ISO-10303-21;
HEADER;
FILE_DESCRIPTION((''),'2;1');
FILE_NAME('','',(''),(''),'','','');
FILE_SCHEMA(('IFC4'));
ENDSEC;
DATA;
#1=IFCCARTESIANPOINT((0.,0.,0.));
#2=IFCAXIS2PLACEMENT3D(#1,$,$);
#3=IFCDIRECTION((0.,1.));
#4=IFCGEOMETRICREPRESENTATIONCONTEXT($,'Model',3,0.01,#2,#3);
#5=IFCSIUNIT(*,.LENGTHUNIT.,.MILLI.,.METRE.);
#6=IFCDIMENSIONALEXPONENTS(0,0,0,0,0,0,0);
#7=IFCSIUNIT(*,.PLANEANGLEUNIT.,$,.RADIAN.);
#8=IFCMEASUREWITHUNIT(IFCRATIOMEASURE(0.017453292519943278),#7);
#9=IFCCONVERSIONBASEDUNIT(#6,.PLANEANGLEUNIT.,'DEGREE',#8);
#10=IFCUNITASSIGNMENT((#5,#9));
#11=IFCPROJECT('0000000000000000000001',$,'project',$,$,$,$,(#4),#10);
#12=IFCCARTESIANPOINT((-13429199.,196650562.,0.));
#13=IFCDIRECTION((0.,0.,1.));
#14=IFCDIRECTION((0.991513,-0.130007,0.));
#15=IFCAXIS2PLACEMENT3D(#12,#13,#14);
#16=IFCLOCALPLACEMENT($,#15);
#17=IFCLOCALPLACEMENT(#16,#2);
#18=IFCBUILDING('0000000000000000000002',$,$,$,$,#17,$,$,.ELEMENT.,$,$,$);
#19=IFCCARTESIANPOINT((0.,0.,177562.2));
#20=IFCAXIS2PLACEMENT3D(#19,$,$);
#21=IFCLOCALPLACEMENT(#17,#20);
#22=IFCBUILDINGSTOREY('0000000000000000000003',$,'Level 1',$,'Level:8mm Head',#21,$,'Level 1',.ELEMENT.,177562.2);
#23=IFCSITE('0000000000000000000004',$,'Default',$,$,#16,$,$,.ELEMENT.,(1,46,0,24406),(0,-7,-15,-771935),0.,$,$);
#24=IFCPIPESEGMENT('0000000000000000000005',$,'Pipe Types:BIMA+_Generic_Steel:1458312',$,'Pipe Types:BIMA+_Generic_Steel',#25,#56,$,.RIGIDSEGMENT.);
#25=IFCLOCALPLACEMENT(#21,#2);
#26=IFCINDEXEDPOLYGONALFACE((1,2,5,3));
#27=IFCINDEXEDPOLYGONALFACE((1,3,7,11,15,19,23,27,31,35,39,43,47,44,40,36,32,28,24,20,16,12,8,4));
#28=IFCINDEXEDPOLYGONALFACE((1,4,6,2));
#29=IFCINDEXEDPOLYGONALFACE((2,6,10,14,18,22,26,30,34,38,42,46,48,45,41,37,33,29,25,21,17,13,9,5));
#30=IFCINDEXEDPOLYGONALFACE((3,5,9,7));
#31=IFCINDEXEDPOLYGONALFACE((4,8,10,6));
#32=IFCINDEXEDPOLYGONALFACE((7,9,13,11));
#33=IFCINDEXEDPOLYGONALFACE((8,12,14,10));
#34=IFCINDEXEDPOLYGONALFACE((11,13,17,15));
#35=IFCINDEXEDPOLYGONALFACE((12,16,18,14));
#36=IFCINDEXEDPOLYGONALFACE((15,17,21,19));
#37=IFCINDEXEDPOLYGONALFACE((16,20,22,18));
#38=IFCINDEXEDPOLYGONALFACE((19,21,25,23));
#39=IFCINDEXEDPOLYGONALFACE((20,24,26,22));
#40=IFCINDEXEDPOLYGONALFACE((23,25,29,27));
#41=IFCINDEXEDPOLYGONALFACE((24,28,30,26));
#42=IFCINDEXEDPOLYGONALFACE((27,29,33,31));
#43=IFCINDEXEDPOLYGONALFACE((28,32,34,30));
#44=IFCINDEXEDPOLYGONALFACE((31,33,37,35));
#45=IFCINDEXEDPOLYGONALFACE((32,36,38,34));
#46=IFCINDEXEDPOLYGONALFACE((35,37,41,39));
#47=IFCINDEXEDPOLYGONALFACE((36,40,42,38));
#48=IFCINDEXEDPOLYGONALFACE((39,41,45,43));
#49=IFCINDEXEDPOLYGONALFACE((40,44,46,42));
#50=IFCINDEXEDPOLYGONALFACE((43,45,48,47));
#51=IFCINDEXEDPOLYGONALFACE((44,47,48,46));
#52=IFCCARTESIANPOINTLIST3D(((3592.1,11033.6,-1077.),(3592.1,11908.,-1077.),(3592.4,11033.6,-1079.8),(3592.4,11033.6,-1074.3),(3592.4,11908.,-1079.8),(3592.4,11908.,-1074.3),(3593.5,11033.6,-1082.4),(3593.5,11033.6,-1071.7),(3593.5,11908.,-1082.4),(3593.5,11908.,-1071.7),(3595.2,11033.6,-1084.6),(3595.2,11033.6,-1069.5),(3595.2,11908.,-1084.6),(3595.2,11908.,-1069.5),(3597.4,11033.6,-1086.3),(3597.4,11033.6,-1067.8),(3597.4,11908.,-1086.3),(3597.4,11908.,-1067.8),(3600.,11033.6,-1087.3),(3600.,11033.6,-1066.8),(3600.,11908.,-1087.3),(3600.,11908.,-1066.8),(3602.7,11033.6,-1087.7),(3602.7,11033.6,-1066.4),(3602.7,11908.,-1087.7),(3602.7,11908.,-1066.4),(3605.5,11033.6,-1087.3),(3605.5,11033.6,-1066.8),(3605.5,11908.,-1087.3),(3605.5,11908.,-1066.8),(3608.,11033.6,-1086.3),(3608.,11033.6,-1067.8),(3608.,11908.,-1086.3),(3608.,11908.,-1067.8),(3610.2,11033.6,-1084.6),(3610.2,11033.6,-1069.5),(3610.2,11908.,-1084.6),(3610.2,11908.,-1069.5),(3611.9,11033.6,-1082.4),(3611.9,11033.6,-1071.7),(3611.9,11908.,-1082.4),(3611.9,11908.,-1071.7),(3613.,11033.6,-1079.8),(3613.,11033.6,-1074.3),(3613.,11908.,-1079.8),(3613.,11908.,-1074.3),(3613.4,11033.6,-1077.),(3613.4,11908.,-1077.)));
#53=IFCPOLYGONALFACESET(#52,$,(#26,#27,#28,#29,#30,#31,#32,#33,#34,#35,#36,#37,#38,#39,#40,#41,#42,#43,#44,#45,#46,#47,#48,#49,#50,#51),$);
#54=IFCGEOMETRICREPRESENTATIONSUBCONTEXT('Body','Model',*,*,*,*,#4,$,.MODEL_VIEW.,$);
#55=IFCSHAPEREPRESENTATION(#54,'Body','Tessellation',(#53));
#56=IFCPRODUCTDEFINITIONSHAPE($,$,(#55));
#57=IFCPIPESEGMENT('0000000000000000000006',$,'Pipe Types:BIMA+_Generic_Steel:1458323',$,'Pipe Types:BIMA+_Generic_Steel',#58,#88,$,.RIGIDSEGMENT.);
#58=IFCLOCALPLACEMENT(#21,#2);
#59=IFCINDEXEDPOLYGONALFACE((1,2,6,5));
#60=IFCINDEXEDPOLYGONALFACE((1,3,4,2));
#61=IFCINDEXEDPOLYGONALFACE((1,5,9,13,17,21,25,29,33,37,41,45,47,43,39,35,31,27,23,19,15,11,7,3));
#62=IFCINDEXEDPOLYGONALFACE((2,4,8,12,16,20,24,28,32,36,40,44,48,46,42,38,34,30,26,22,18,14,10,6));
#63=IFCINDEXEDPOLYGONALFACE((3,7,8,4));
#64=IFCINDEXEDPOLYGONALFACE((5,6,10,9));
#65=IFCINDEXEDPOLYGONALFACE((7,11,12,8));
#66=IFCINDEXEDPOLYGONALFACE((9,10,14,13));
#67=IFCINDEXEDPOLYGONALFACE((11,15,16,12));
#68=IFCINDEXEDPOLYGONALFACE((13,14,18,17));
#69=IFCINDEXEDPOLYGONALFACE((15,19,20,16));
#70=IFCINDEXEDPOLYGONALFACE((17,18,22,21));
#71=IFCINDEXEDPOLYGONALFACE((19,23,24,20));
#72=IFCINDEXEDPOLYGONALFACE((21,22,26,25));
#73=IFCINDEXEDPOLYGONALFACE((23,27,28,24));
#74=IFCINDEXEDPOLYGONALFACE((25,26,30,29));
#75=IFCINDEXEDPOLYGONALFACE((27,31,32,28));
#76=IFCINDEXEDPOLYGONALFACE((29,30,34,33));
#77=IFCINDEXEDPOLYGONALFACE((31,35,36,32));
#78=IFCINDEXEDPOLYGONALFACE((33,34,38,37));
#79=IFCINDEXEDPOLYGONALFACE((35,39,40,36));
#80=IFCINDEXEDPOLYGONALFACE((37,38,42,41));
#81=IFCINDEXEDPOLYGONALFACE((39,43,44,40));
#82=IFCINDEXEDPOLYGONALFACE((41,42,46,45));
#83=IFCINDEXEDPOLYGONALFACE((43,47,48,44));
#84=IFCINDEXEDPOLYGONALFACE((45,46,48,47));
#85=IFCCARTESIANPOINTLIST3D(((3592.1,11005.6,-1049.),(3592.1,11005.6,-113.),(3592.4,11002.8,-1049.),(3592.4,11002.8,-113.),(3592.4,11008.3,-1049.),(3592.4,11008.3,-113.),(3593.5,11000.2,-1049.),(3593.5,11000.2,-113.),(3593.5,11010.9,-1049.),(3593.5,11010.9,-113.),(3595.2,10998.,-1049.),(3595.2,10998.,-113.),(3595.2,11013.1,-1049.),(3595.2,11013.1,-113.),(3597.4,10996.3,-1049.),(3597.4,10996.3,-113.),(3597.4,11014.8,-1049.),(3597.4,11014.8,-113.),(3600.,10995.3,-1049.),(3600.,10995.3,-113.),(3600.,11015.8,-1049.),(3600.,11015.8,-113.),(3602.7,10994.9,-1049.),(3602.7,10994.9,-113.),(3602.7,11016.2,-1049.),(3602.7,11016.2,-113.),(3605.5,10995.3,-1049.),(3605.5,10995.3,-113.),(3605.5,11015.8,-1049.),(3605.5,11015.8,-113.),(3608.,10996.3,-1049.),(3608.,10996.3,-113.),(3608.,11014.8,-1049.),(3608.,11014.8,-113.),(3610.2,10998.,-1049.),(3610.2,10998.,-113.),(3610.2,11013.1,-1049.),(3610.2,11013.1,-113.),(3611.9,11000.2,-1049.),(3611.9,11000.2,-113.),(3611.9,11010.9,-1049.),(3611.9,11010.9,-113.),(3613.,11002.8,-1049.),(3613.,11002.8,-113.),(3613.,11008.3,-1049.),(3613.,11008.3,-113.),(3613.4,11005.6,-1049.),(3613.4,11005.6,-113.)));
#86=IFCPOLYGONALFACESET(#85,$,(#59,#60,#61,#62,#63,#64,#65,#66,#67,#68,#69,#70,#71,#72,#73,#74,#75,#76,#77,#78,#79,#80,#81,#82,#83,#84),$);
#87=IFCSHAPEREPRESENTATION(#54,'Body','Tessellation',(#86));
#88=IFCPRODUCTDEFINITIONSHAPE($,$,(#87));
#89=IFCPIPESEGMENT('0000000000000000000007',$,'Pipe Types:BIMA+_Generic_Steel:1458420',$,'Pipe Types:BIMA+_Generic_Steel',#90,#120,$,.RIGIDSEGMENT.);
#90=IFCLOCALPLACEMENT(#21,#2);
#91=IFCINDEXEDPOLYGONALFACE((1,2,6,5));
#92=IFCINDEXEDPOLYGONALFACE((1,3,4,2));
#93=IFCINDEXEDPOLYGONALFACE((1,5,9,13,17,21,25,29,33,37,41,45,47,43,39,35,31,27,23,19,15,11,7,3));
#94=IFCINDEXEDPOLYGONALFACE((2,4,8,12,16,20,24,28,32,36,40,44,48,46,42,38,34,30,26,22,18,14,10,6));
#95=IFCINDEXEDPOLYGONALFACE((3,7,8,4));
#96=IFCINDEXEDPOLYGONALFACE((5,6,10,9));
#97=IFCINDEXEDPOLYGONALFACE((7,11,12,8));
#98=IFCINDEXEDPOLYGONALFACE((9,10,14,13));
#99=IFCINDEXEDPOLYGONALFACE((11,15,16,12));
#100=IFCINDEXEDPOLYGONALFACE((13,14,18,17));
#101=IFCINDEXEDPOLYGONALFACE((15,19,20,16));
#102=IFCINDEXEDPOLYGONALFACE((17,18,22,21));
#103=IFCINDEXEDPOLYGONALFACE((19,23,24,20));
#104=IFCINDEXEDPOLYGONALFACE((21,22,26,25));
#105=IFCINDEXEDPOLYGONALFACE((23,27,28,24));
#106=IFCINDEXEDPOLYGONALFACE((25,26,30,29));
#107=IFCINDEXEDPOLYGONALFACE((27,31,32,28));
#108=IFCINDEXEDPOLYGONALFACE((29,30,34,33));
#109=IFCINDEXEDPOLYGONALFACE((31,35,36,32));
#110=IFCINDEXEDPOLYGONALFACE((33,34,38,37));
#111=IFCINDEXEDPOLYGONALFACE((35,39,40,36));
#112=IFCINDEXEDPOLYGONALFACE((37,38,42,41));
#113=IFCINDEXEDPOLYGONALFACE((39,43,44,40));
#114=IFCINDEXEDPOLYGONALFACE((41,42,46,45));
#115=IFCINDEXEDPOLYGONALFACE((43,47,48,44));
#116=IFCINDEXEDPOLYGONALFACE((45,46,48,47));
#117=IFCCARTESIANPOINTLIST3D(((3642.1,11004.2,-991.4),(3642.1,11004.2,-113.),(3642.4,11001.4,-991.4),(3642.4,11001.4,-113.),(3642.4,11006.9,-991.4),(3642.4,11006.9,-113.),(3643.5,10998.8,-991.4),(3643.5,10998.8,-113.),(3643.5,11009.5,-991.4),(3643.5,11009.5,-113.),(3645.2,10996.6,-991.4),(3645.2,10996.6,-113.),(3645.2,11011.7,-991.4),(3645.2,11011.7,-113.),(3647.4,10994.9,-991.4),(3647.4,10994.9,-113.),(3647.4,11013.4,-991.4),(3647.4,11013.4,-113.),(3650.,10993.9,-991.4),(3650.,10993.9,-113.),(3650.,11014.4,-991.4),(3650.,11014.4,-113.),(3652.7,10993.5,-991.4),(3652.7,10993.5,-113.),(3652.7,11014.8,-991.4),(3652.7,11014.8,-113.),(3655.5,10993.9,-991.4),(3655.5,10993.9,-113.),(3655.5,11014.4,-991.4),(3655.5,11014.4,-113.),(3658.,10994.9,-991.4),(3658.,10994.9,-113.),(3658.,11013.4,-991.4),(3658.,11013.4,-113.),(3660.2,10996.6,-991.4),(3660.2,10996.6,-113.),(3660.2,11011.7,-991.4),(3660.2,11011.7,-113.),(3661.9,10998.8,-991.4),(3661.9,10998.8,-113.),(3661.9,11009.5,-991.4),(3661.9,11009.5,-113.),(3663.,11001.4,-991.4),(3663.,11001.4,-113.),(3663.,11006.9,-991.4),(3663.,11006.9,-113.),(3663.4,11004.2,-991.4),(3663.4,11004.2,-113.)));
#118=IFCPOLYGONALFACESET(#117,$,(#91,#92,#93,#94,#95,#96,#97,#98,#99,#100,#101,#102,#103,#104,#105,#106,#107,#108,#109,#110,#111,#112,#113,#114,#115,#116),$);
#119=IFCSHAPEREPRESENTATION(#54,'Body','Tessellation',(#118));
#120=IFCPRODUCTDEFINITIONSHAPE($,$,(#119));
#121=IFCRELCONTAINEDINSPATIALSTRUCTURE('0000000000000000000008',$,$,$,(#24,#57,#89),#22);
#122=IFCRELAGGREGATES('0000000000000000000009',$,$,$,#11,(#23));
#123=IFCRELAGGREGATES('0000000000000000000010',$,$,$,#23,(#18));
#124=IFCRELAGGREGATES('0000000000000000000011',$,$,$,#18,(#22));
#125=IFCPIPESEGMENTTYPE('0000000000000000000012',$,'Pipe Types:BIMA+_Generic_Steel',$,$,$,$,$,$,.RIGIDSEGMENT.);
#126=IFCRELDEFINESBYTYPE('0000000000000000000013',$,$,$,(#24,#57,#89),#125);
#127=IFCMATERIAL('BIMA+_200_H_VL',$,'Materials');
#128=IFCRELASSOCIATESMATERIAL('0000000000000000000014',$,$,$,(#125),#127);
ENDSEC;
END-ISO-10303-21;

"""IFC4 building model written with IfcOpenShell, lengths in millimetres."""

from ifc_helpers import new_model, entity, si_unit, converted_unit, direction, frame, origin, place, context, subcontext, project, spatial, arc, indexed_curve, outline, extrude, material, type_object, element, save


model = new_model("IFC4")

# Units and contexts
model_context = context("Model", 3, precision=0.01, world=origin(), true_north=direction((0.0, 1.0)))
body_context = subcontext(model_context, "Body", "Model", "MODEL_VIEW")
ifc_project = project(units=[si_unit("LENGTHUNIT", "METRE", prefix="MILLI"), converted_unit("PLANEANGLEUNIT", "DEGREE", entity("IfcRatioMeasure", 0.017453292519943278), si_unit("PLANEANGLEUNIT", "RADIAN"), dimensions=[0, 0, 0, 0, 0, 0, 0])], contexts=[model_context])

# Site, building, storey
site_placement = place(None, frame((-13429199.0, 196650562.0, 0.0), z_axis=(0.0, 0.0, 1.0), x_axis=(0.991513, -0.130007, 0.0)))
site = spatial("IfcSite", under=ifc_project, at=site_placement, Name="Default", CompositionType="ELEMENT", RefLatitude=(1, 46, 0, 24406), RefLongitude=(0, -7, -15, -771935), RefElevation=0.0)
building_placement = place(site_placement, origin())
building = spatial("IfcBuilding", under=site, at=building_placement, CompositionType="ELEMENT")
storey_placement = place(building_placement, frame((0.0, 0.0, 177562.2)))
storey = spatial("IfcBuildingStorey", under=building, at=storey_placement, Name="Level 1", ObjectType="Level:8mm Head", LongName="Level 1", CompositionType="ELEMENT", Elevation=177562.2)

# Pipe segments
ifc_material_1 = material(Name="BIMA+_200_H_VL", Category="Materials")
pipe_segment_type_1 = type_object("IfcPipeSegmentType", Name="Pipe Types:BIMA+_Generic_Steel", PredefinedType="RIGIDSEGMENT", material=ifc_material_1)
pipe_segment_1_placement = place(storey_placement, frame((3590.5, 11033.6, -1089.3)))
element("IfcPipeSegment", 1, at=pipe_segment_1_placement, inside=storey, type_object=pipe_segment_type_1, Name="Pipe Types:BIMA+_Generic_Steel:1458312", ObjectType="Pipe Types:BIMA+_Generic_Steel", PredefinedType="RIGIDSEGMENT", context=body_context, shape_type="SweptSolid", body=[
    extrude(outline(indexed_curve([(10.6, 0.0), (7.5, 7.5), (0.0, 10.7), (-7.5, 7.5), (-10.6, 0.0), (-7.5, -7.5), (0.0, -10.7), (7.5, -7.5)], segments=[arc(1, 2, 3), arc(3, 4, 5), arc(5, 6, 7), arc(7, 8, 1)], self_intersect=False)), frame((12.2, 0.0, 12.2), z_axis=(0.0, 1.0, 0.0), x_axis=(1.0, 0.0, 0.0)), (0.0, 0.0, 1.0), 874.5),
])
pipe_segment_2_placement = place(storey_placement, frame((3590.5, 10993.3, -1049.0)))
element("IfcPipeSegment", 2, at=pipe_segment_2_placement, inside=storey, type_object=pipe_segment_type_1, Name="Pipe Types:BIMA+_Generic_Steel:1458323", ObjectType="Pipe Types:BIMA+_Generic_Steel", PredefinedType="RIGIDSEGMENT", context=body_context, shape_type="SweptSolid", body=[
    extrude(outline(indexed_curve([(10.6, 0.0), (7.5, 7.5), (0.0, 10.6), (-7.5, 7.5), (-10.6, 0.0), (-7.5, -7.5), (0.0, -10.6), (7.5, -7.5)], segments=[arc(1, 2, 3), arc(3, 4, 5), arc(5, 6, 7), arc(7, 8, 1)], self_intersect=False)), frame((12.2, 12.2, 0.0)), (0.0, 0.0, 1.0), 936.0),
])
pipe_segment_3_placement = place(storey_placement, frame((3640.5, 10991.9, -991.4)))
element("IfcPipeSegment", 3, at=pipe_segment_3_placement, inside=storey, type_object=pipe_segment_type_1, Name="Pipe Types:BIMA+_Generic_Steel:1458420", ObjectType="Pipe Types:BIMA+_Generic_Steel", PredefinedType="RIGIDSEGMENT", context=body_context, shape_type="SweptSolid", body=[
    extrude(outline(indexed_curve([(10.6, 0.0), (7.5, 7.5), (0.0, 10.6), (-7.5, 7.5), (-10.6, 0.0), (-7.5, -7.5), (0.0, -10.6), (7.5, -7.5)], segments=[arc(1, 2, 3), arc(3, 4, 5), arc(5, 6, 7), arc(7, 8, 1)], self_intersect=False)), frame((12.2, 12.2, 0.0)), (0.0, 0.0, 1.0), 878.4),
])

save(model, "model.ifc")
